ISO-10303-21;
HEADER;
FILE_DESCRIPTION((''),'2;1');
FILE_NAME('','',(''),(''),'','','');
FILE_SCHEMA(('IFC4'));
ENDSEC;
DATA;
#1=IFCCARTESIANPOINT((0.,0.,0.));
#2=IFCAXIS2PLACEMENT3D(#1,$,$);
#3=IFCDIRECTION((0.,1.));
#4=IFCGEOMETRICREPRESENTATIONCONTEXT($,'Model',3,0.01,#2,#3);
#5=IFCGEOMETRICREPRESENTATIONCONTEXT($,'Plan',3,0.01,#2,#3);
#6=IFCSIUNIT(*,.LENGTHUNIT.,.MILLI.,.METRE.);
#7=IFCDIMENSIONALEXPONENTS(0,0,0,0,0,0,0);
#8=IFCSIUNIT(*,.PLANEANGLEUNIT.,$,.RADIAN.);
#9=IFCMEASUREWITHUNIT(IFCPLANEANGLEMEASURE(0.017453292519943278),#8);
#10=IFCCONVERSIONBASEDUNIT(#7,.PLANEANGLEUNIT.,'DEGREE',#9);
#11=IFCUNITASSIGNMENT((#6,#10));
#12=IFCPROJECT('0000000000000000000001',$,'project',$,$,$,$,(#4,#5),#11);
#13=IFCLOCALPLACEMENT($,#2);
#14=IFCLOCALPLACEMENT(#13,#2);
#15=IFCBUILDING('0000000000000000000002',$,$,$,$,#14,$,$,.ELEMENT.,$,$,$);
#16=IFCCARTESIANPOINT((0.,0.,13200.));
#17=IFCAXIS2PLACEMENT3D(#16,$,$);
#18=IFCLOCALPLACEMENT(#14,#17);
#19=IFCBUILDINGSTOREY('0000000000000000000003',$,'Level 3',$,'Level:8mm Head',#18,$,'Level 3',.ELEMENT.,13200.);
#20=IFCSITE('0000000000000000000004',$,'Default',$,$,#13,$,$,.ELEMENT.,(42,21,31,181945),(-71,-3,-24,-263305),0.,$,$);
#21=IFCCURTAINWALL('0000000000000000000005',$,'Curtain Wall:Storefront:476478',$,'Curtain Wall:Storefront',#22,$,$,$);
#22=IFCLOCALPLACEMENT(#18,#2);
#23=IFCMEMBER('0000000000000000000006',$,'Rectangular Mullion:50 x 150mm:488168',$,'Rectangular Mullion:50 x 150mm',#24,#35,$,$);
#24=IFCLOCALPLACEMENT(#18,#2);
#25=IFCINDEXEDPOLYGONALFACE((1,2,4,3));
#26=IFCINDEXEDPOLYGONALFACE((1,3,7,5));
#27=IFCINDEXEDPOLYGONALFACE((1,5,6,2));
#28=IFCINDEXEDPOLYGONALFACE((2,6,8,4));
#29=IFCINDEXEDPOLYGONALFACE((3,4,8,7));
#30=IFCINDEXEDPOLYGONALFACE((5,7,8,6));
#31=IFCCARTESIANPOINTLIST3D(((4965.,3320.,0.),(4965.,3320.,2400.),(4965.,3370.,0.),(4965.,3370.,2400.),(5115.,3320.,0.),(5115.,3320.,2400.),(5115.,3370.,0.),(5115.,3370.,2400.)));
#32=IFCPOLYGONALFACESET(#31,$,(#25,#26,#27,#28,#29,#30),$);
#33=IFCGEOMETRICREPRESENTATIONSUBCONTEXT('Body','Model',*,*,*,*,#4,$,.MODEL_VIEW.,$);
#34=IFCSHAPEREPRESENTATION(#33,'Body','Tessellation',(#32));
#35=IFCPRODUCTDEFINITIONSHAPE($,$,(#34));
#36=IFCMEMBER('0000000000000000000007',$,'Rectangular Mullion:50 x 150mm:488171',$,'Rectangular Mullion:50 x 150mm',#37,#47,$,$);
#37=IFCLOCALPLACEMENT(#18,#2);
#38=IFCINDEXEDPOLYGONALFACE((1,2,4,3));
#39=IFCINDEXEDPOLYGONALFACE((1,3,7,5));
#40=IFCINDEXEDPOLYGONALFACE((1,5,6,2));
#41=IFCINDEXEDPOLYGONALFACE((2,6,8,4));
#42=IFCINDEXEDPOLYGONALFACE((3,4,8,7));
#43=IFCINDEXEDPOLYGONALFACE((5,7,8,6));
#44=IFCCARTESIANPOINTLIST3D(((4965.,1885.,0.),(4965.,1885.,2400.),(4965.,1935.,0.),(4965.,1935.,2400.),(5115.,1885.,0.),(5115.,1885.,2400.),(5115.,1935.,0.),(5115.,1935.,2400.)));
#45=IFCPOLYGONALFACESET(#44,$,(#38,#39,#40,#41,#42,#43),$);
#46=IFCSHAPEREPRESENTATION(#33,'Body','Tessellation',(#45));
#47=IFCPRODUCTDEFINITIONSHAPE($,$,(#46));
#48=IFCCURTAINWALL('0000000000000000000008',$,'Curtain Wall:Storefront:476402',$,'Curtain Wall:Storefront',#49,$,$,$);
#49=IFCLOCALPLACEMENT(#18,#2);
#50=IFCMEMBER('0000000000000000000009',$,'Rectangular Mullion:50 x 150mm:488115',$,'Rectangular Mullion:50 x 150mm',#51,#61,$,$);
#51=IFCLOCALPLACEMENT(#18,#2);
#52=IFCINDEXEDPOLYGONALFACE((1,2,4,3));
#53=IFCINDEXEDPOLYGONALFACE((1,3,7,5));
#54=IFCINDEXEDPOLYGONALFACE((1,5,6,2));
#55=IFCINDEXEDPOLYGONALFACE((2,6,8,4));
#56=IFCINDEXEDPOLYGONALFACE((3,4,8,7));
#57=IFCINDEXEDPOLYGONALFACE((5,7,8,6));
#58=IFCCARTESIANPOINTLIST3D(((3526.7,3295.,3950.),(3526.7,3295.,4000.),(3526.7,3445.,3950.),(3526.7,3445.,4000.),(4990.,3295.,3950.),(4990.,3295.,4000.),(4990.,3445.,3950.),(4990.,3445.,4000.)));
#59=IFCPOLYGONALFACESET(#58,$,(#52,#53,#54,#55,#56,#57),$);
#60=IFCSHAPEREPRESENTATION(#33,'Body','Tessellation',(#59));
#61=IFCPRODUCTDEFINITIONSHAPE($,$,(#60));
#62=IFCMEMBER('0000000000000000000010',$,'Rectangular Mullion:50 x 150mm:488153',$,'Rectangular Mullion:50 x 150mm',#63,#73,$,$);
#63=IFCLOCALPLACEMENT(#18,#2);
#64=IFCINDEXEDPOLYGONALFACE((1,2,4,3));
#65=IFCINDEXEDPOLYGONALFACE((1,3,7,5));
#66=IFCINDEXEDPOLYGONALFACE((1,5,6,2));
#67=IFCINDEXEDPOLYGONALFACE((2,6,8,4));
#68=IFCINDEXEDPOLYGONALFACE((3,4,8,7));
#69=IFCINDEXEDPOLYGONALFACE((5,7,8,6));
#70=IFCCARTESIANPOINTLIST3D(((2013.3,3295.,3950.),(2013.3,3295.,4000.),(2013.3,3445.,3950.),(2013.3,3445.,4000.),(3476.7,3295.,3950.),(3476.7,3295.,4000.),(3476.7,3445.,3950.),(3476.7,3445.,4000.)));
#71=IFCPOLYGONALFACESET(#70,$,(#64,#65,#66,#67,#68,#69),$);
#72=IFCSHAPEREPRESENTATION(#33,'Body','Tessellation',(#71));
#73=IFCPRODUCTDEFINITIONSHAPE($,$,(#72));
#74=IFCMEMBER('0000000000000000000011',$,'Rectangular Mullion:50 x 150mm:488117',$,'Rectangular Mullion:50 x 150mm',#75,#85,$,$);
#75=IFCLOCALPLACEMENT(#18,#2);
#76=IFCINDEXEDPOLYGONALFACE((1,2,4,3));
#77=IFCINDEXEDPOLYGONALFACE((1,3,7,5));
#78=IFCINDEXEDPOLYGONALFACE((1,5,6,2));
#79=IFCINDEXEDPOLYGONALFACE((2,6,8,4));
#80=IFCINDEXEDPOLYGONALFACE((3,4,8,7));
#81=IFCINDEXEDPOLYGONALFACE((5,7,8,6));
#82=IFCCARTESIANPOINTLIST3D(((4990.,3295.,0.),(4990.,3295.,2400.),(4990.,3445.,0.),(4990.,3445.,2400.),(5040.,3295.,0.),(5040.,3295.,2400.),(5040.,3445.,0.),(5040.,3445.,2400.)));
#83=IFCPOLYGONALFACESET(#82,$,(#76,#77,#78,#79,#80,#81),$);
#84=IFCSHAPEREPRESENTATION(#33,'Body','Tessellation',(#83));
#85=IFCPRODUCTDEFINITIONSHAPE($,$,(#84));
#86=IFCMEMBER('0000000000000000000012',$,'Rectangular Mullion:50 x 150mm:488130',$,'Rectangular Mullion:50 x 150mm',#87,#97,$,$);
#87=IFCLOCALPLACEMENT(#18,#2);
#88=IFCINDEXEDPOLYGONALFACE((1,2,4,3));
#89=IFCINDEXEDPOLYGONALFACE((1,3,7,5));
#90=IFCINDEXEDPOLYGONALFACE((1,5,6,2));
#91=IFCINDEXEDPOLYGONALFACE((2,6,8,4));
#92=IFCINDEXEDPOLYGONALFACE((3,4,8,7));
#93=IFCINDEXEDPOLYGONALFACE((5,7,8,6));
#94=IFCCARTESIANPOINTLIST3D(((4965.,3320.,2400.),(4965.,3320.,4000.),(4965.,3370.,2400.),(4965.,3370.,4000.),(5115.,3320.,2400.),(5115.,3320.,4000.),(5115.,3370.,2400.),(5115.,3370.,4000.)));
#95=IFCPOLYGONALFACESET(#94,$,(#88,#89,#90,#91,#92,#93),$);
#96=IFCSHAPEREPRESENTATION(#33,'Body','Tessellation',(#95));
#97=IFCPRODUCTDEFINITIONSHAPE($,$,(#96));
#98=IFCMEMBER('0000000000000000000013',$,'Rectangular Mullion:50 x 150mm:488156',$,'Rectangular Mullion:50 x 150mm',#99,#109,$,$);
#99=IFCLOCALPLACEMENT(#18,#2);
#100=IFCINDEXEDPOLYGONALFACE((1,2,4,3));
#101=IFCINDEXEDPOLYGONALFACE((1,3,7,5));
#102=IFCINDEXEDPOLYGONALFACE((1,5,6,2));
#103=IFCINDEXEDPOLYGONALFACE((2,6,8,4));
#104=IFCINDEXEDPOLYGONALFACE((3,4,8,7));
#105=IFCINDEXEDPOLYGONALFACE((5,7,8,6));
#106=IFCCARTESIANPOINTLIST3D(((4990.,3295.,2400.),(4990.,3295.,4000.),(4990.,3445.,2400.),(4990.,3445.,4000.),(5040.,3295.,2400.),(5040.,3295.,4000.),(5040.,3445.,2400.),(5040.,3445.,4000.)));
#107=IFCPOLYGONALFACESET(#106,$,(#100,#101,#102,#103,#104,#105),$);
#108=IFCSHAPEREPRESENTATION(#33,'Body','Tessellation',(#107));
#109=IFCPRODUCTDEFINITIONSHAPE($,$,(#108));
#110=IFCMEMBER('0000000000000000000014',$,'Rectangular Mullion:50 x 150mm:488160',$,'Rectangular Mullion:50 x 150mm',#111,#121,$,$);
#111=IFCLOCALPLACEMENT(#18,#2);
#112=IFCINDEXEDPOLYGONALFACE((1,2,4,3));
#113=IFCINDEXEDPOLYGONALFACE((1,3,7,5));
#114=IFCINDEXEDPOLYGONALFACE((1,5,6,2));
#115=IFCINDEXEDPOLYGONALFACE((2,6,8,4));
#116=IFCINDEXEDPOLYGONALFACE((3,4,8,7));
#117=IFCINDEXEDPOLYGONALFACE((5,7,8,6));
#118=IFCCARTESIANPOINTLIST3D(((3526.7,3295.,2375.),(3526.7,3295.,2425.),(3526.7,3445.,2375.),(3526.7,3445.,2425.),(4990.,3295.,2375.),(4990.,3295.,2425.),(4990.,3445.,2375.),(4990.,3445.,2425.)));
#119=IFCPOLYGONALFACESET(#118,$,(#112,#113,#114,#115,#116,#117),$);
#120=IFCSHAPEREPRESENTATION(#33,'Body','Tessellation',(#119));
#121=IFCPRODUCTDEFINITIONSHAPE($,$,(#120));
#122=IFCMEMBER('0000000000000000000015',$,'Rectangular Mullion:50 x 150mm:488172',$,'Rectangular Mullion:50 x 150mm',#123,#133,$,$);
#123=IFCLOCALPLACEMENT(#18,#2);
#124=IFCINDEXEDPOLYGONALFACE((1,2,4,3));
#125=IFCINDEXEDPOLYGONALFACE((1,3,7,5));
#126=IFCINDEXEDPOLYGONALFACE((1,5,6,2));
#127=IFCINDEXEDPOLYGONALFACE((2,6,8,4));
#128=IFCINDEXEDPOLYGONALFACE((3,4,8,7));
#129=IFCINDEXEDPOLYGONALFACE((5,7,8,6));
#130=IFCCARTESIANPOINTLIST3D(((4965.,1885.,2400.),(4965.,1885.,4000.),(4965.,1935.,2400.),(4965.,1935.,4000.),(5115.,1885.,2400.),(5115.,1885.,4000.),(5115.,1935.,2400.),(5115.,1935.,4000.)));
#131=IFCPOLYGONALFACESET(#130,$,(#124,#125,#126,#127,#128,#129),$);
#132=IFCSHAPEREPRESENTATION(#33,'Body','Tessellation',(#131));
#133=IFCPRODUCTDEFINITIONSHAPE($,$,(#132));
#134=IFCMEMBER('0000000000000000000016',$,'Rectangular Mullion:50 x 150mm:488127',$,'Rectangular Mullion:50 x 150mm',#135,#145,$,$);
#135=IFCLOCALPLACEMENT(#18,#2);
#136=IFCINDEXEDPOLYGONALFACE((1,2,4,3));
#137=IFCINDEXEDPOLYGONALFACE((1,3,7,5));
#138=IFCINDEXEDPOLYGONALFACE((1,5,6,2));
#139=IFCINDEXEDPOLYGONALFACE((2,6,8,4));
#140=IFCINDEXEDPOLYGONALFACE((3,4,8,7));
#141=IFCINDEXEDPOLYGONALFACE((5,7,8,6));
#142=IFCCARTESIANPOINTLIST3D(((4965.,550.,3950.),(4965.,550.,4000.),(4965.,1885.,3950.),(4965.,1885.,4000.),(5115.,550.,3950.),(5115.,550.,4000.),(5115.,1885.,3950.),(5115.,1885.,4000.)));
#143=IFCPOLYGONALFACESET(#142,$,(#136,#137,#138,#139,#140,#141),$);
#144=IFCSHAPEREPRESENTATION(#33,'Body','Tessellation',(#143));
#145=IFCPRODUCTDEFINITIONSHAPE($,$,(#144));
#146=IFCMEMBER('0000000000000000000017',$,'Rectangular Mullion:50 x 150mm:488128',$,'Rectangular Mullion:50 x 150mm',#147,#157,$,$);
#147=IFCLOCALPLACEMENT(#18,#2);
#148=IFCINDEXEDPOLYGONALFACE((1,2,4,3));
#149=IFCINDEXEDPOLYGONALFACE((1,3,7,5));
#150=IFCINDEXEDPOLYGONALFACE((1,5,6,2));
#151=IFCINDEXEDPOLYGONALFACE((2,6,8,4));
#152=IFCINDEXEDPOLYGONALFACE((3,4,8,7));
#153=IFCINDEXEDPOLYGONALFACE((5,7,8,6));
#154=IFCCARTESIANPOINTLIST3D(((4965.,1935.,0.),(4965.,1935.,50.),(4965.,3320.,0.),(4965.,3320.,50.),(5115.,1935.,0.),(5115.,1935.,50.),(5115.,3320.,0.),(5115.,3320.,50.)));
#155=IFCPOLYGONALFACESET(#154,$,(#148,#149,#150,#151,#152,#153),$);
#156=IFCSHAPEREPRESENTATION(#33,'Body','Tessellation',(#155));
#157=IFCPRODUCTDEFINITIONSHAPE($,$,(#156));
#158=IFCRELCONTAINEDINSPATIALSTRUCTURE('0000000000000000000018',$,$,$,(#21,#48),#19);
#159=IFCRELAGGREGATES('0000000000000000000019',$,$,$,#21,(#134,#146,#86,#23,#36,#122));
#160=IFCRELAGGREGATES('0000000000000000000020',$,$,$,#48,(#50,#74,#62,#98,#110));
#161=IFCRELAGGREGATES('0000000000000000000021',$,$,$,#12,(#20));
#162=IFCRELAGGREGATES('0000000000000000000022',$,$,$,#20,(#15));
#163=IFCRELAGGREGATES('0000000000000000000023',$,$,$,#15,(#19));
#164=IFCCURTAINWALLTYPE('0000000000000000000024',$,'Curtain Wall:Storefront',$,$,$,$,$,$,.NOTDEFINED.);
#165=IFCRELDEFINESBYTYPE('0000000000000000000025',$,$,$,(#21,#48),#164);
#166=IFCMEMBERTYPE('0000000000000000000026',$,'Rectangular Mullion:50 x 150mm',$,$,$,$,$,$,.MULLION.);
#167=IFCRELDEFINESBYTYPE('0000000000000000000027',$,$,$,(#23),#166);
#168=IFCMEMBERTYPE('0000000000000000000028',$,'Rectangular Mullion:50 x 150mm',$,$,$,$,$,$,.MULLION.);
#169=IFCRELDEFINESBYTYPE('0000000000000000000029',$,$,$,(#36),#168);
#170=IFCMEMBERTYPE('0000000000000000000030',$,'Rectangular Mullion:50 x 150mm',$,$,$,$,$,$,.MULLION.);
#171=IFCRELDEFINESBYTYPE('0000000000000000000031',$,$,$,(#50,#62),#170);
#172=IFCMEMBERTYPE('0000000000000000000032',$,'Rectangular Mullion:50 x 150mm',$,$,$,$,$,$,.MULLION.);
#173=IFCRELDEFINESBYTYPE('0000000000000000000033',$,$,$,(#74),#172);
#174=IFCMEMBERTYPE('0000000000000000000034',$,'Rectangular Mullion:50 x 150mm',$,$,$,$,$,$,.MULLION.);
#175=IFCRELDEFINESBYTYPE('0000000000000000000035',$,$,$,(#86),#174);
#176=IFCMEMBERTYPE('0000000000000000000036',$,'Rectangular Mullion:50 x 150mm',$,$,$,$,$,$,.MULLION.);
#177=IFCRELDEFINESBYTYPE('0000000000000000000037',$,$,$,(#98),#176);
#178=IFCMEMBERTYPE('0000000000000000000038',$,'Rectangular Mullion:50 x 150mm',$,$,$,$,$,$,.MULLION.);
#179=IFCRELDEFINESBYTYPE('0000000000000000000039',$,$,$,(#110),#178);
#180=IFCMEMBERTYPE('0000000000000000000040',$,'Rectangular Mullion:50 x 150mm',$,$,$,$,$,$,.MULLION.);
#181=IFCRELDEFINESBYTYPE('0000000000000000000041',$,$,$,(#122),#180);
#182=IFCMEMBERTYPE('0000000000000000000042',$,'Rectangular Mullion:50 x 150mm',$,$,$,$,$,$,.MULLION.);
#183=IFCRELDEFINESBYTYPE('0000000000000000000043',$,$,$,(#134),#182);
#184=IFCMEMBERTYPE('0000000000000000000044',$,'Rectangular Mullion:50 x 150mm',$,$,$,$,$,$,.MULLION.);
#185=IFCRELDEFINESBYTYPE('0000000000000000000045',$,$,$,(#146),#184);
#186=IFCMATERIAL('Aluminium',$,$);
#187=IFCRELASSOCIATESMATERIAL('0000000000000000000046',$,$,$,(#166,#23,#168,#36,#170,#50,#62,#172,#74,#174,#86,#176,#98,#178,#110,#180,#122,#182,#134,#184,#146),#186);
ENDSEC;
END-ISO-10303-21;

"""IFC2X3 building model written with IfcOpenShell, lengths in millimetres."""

from ifc_helpers import new_model, entity, si_unit, converted_unit, direction, frame, origin, origin_2d_with_axis, place, context, subcontext, project, spatial, rectangle, extrude, source, transform, mapped, material, type_object, type_shapes, element, aggregate, save


model = new_model("IFC2X3")

# Units and contexts
model_context = context("Model", 3, precision=0.01, world=origin(), true_north=direction((0.0, 1.0)))
plan_context = context("Plan", 3, precision=0.01, world=origin(), true_north=direction((0.0, 1.0)))
body_context = subcontext(model_context, "Body", "Model", "MODEL_VIEW")
ifc_project = project(units=[si_unit("LENGTHUNIT", "METRE", prefix="MILLI"), converted_unit("PLANEANGLEUNIT", "DEGREE", entity("IfcPlaneAngleMeasure", 0.017453292519943278), si_unit("PLANEANGLEUNIT", "RADIAN"), dimensions=[0, 0, 0, 0, 0, 0, 0])], contexts=[model_context, plan_context])

# Site, building, storey
site_placement = place(None, origin())
site = spatial("IfcSite", under=ifc_project, at=site_placement, Name="Default", CompositionType="ELEMENT", RefLatitude=(42, 21, 31, 181945), RefLongitude=(-71, -3, -24, -263305), RefElevation=0.0)
building_placement = place(site_placement, origin())
building = spatial("IfcBuilding", under=site, at=building_placement, CompositionType="ELEMENT")
storey_placement = place(building_placement, frame((0.0, 0.0, 13200.0)))
storey = spatial("IfcBuildingStorey", under=building, at=storey_placement, Name="Level 3", ObjectType="Level:8mm Head", LongName="Level 3", CompositionType="ELEMENT", Elevation=13200.0)

# Curtain walls, members
curtain_wall_type = type_object("IfcCurtainWallType", Name="Curtain Wall:Storefront", PredefinedType="NOTDEFINED")
curtain_wall_1_placement = place(storey_placement, frame((0.0, 0.0, -13200.0)))
curtain_wall_1 = element("IfcCurtainWall", 1, at=curtain_wall_1_placement, inside=storey, type_object=curtain_wall_type, Name="Curtain Wall:Storefront:476478", ObjectType="Curtain Wall:Storefront")
ifc_material_1 = material(Name="Aluminium")
member_type_1 = type_object("IfcMemberType", Name="Rectangular Mullion:50 x 150mm", PredefinedType="MULLION", material=ifc_material_1)
shared_shape_1 = source(origin(), body_context, "Body", "SweptSolid", [
    extrude(rectangle(XDim=50.0, YDim=150.0, at=origin_2d_with_axis()), frame((-25.0, 0.0, -2400.0), z_axis=(0.0, 0.0, 1.0), x_axis=(-1.0, 0.0, 0.0)), (0.0, 0.0, 1.0), 2400.0),
])
type_shapes(member_type_1, [shared_shape_1])
member_1_placement = place(curtain_wall_1_placement, frame((5040.0, 3370.0, 15600.0), z_axis=(0.0, 0.0, 1.0), x_axis=(0.0, 1.0, 0.0)))
member_1 = element("IfcMember", 2, at=member_1_placement, type_object=member_type_1, material=ifc_material_1, Name="Rectangular Mullion:50 x 150mm:488168", ObjectType="Rectangular Mullion:50 x 150mm", context=body_context, shape_type="MappedRepresentation", body=[
    mapped(shared_shape_1, transform((0.0, 0.0, 0.0), scale=1.0)),
])
member_type_2 = type_object("IfcMemberType", Name="Rectangular Mullion:50 x 150mm", PredefinedType="MULLION", material=ifc_material_1)
shared_shape_2 = source(origin(), body_context, "Body", "SweptSolid", [
    extrude(rectangle(XDim=50.0, YDim=150.0, at=origin_2d_with_axis()), frame((0.0, 0.0, -2400.0), z_axis=(0.0, 0.0, 1.0), x_axis=(-1.0, 0.0, 0.0)), (0.0, 0.0, 1.0), 2400.0),
])
type_shapes(member_type_2, [shared_shape_2])
member_2_placement = place(curtain_wall_1_placement, frame((5040.0, 1910.0, 13200.0), z_axis=(0.0, 0.0, -1.0), x_axis=(0.0, -1.0, 0.0)))
member_2 = element("IfcMember", 3, at=member_2_placement, type_object=member_type_2, material=ifc_material_1, Name="Rectangular Mullion:50 x 150mm:488171", ObjectType="Rectangular Mullion:50 x 150mm", context=body_context, shape_type="MappedRepresentation", body=[
    mapped(shared_shape_2, transform((0.0, 0.0, 0.0), scale=1.0)),
])
curtain_wall_2_placement = place(storey_placement, frame((0.0, 0.0, -13200.0)))
curtain_wall_2 = element("IfcCurtainWall", 4, at=curtain_wall_2_placement, inside=storey, type_object=curtain_wall_type, Name="Curtain Wall:Storefront:476402", ObjectType="Curtain Wall:Storefront")
member_type_3 = type_object("IfcMemberType", Name="Rectangular Mullion:50 x 150mm", PredefinedType="MULLION", material=ifc_material_1)
shared_shape_3 = source(origin(), body_context, "Body", "SweptSolid", [
    extrude(rectangle(XDim=50.0, YDim=150.0, at=origin_2d_with_axis()), frame((-25.0, 0.0, -1463.3), z_axis=(0.0, 0.0, 1.0), x_axis=(-1.0, 0.0, 0.0)), (0.0, 0.0, 1.0), 1463.3),
])
type_shapes(member_type_3, [shared_shape_3])
member_3_placement = place(curtain_wall_2_placement, frame((4990.0, 3370.0, 17200.0), z_axis=(1.0, 0.0, 0.0), x_axis=(0.0, 0.0, 1.0)))
member_3 = element("IfcMember", 5, at=member_3_placement, type_object=member_type_3, material=ifc_material_1, Name="Rectangular Mullion:50 x 150mm:488115", ObjectType="Rectangular Mullion:50 x 150mm", context=body_context, shape_type="MappedRepresentation", body=[
    mapped(shared_shape_3, transform((0.0, 0.0, 0.0), scale=1.0)),
])
member_4_placement = place(curtain_wall_2_placement, frame((3476.7, 3370.0, 17200.0), z_axis=(1.0, 0.0, 0.0), x_axis=(0.0, 0.0, 1.0)))
member_4 = element("IfcMember", 6, at=member_4_placement, type_object=member_type_3, material=ifc_material_1, Name="Rectangular Mullion:50 x 150mm:488153", ObjectType="Rectangular Mullion:50 x 150mm", context=body_context, shape_type="MappedRepresentation", body=[
    mapped(shared_shape_3, transform((0.0, 0.0, 0.0), scale=1.0)),
])
member_type_4 = type_object("IfcMemberType", Name="Rectangular Mullion:50 x 150mm", PredefinedType="MULLION", material=ifc_material_1)
shared_shape_4 = source(origin(), body_context, "Body", "SweptSolid", [
    extrude(rectangle(XDim=50.0, YDim=150.0, at=origin_2d_with_axis()), frame((-25.0, 0.0, -2400.0), z_axis=(0.0, 0.0, 1.0), x_axis=(-1.0, 0.0, 0.0)), (0.0, 0.0, 1.0), 2400.0),
])
type_shapes(member_type_4, [shared_shape_4])
member_5_placement = place(curtain_wall_2_placement, frame((5040.0, 3370.0, 13200.0), z_axis=(0.0, 0.0, -1.0), x_axis=(1.0, 0.0, 0.0)))
member_5 = element("IfcMember", 7, at=member_5_placement, type_object=member_type_4, material=ifc_material_1, Name="Rectangular Mullion:50 x 150mm:488117", ObjectType="Rectangular Mullion:50 x 150mm", context=body_context, shape_type="MappedRepresentation", body=[
    mapped(shared_shape_4, transform((0.0, 0.0, 0.0), scale=1.0)),
])

# Members
member_type_5 = type_object("IfcMemberType", Name="Rectangular Mullion:50 x 150mm", PredefinedType="MULLION", material=ifc_material_1)
shared_shape_5 = source(origin(), body_context, "Body", "SweptSolid", [
    extrude(rectangle(XDim=50.0, YDim=150.0, at=origin_2d_with_axis()), frame((-25.0, 0.0, -1600.0), z_axis=(0.0, 0.0, 1.0), x_axis=(-1.0, 0.0, 0.0)), (0.0, 0.0, 1.0), 1600.0),
])
type_shapes(member_type_5, [shared_shape_5])
member_6_placement = place(curtain_wall_1_placement, frame((5040.0, 3370.0, 17200.0), z_axis=(0.0, 0.0, 1.0), x_axis=(0.0, 1.0, 0.0)))
member_6 = element("IfcMember", 8, at=member_6_placement, type_object=member_type_5, material=ifc_material_1, Name="Rectangular Mullion:50 x 150mm:488130", ObjectType="Rectangular Mullion:50 x 150mm", context=body_context, shape_type="MappedRepresentation", body=[
    mapped(shared_shape_5, transform((0.0, 0.0, 0.0), scale=1.0)),
])
member_type_6 = type_object("IfcMemberType", Name="Rectangular Mullion:50 x 150mm", PredefinedType="MULLION", material=ifc_material_1)
shared_shape_6 = source(origin(), body_context, "Body", "SweptSolid", [
    extrude(rectangle(XDim=50.0, YDim=150.0, at=origin_2d_with_axis()), frame((-25.0, 0.0, -1600.0), z_axis=(0.0, 0.0, 1.0), x_axis=(-1.0, 0.0, 0.0)), (0.0, 0.0, 1.0), 1600.0),
])
type_shapes(member_type_6, [shared_shape_6])
member_7_placement = place(curtain_wall_2_placement, frame((5040.0, 3370.0, 15600.0), z_axis=(0.0, 0.0, -1.0), x_axis=(1.0, 0.0, 0.0)))
member_7 = element("IfcMember", 9, at=member_7_placement, type_object=member_type_6, material=ifc_material_1, Name="Rectangular Mullion:50 x 150mm:488156", ObjectType="Rectangular Mullion:50 x 150mm", context=body_context, shape_type="MappedRepresentation", body=[
    mapped(shared_shape_6, transform((0.0, 0.0, 0.0), scale=1.0)),
])
member_type_7 = type_object("IfcMemberType", Name="Rectangular Mullion:50 x 150mm", PredefinedType="MULLION", material=ifc_material_1)
shared_shape_7 = source(origin(), body_context, "Body", "SweptSolid", [
    extrude(rectangle(XDim=50.0, YDim=150.0, at=origin_2d_with_axis()), frame((0.0, 0.0, -1463.3), z_axis=(0.0, 0.0, 1.0), x_axis=(-1.0, 0.0, 0.0)), (0.0, 0.0, 1.0), 1463.3),
])
type_shapes(member_type_7, [shared_shape_7])
member_8_placement = place(curtain_wall_2_placement, frame((4990.0, 3370.0, 15600.0), z_axis=(1.0, 0.0, 0.0), x_axis=(0.0, 0.0, 1.0)))
member_8 = element("IfcMember", 10, at=member_8_placement, type_object=member_type_7, material=ifc_material_1, Name="Rectangular Mullion:50 x 150mm:488160", ObjectType="Rectangular Mullion:50 x 150mm", context=body_context, shape_type="MappedRepresentation", body=[
    mapped(shared_shape_7, transform((0.0, 0.0, 0.0), scale=1.0)),
])
member_type_8 = type_object("IfcMemberType", Name="Rectangular Mullion:50 x 150mm", PredefinedType="MULLION", material=ifc_material_1)
shared_shape_8 = source(origin(), body_context, "Body", "SweptSolid", [
    extrude(rectangle(XDim=50.0, YDim=150.0, at=origin_2d_with_axis()), frame((0.0, 0.0, -1600.0), z_axis=(0.0, 0.0, 1.0), x_axis=(-1.0, 0.0, 0.0)), (0.0, 0.0, 1.0), 1600.0),
])
type_shapes(member_type_8, [shared_shape_8])
member_9_placement = place(curtain_wall_1_placement, frame((5040.0, 1910.0, 15600.0), z_axis=(0.0, 0.0, -1.0), x_axis=(0.0, -1.0, 0.0)))
member_9 = element("IfcMember", 11, at=member_9_placement, type_object=member_type_8, material=ifc_material_1, Name="Rectangular Mullion:50 x 150mm:488172", ObjectType="Rectangular Mullion:50 x 150mm", context=body_context, shape_type="MappedRepresentation", body=[
    mapped(shared_shape_8, transform((0.0, 0.0, 0.0), scale=1.0)),
])
member_type_9 = type_object("IfcMemberType", Name="Rectangular Mullion:50 x 150mm", PredefinedType="MULLION", material=ifc_material_1)
shared_shape_9 = source(origin(), body_context, "Body", "SweptSolid", [
    extrude(rectangle(XDim=50.0, YDim=150.0, at=origin_2d_with_axis()), frame((-25.0, 0.0, -1335.0), z_axis=(0.0, 0.0, 1.0), x_axis=(-1.0, 0.0, 0.0)), (0.0, 0.0, 1.0), 1335.0),
])
type_shapes(member_type_9, [shared_shape_9])
member_10_placement = place(curtain_wall_1_placement, frame((5040.0, 550.0, 17200.0), z_axis=(0.0, -1.0, 0.0), x_axis=(0.0, 0.0, 1.0)))
member_10 = element("IfcMember", 12, at=member_10_placement, type_object=member_type_9, material=ifc_material_1, Name="Rectangular Mullion:50 x 150mm:488127", ObjectType="Rectangular Mullion:50 x 150mm", context=body_context, shape_type="MappedRepresentation", body=[
    mapped(shared_shape_9, transform((0.0, 0.0, 0.0), scale=1.0)),
])
member_type_10 = type_object("IfcMemberType", Name="Rectangular Mullion:50 x 150mm", PredefinedType="MULLION", material=ifc_material_1)
shared_shape_10 = source(origin(), body_context, "Body", "SweptSolid", [
    extrude(rectangle(XDim=50.0, YDim=150.0, at=origin_2d_with_axis()), frame((-25.0, 0.0, -1385.0), z_axis=(0.0, 0.0, 1.0), x_axis=(-1.0, 0.0, 0.0)), (0.0, 0.0, 1.0), 1385.0),
])
type_shapes(member_type_10, [shared_shape_10])
member_11_placement = place(curtain_wall_1_placement, frame((5040.0, 3320.0, 13200.0), z_axis=(0.0, 1.0, 0.0), x_axis=(0.0, 0.0, -1.0)))
member_11 = element("IfcMember", 13, at=member_11_placement, type_object=member_type_10, material=ifc_material_1, Name="Rectangular Mullion:50 x 150mm:488128", ObjectType="Rectangular Mullion:50 x 150mm", context=body_context, shape_type="MappedRepresentation", body=[
    mapped(shared_shape_10, transform((0.0, 0.0, 0.0), scale=1.0)),
])

aggregate(curtain_wall_1, [member_10, member_11, member_6, member_1, member_2, member_9])

aggregate(curtain_wall_2, [member_3, member_5, member_4, member_7, member_8])

save(model, "model.ifc")
